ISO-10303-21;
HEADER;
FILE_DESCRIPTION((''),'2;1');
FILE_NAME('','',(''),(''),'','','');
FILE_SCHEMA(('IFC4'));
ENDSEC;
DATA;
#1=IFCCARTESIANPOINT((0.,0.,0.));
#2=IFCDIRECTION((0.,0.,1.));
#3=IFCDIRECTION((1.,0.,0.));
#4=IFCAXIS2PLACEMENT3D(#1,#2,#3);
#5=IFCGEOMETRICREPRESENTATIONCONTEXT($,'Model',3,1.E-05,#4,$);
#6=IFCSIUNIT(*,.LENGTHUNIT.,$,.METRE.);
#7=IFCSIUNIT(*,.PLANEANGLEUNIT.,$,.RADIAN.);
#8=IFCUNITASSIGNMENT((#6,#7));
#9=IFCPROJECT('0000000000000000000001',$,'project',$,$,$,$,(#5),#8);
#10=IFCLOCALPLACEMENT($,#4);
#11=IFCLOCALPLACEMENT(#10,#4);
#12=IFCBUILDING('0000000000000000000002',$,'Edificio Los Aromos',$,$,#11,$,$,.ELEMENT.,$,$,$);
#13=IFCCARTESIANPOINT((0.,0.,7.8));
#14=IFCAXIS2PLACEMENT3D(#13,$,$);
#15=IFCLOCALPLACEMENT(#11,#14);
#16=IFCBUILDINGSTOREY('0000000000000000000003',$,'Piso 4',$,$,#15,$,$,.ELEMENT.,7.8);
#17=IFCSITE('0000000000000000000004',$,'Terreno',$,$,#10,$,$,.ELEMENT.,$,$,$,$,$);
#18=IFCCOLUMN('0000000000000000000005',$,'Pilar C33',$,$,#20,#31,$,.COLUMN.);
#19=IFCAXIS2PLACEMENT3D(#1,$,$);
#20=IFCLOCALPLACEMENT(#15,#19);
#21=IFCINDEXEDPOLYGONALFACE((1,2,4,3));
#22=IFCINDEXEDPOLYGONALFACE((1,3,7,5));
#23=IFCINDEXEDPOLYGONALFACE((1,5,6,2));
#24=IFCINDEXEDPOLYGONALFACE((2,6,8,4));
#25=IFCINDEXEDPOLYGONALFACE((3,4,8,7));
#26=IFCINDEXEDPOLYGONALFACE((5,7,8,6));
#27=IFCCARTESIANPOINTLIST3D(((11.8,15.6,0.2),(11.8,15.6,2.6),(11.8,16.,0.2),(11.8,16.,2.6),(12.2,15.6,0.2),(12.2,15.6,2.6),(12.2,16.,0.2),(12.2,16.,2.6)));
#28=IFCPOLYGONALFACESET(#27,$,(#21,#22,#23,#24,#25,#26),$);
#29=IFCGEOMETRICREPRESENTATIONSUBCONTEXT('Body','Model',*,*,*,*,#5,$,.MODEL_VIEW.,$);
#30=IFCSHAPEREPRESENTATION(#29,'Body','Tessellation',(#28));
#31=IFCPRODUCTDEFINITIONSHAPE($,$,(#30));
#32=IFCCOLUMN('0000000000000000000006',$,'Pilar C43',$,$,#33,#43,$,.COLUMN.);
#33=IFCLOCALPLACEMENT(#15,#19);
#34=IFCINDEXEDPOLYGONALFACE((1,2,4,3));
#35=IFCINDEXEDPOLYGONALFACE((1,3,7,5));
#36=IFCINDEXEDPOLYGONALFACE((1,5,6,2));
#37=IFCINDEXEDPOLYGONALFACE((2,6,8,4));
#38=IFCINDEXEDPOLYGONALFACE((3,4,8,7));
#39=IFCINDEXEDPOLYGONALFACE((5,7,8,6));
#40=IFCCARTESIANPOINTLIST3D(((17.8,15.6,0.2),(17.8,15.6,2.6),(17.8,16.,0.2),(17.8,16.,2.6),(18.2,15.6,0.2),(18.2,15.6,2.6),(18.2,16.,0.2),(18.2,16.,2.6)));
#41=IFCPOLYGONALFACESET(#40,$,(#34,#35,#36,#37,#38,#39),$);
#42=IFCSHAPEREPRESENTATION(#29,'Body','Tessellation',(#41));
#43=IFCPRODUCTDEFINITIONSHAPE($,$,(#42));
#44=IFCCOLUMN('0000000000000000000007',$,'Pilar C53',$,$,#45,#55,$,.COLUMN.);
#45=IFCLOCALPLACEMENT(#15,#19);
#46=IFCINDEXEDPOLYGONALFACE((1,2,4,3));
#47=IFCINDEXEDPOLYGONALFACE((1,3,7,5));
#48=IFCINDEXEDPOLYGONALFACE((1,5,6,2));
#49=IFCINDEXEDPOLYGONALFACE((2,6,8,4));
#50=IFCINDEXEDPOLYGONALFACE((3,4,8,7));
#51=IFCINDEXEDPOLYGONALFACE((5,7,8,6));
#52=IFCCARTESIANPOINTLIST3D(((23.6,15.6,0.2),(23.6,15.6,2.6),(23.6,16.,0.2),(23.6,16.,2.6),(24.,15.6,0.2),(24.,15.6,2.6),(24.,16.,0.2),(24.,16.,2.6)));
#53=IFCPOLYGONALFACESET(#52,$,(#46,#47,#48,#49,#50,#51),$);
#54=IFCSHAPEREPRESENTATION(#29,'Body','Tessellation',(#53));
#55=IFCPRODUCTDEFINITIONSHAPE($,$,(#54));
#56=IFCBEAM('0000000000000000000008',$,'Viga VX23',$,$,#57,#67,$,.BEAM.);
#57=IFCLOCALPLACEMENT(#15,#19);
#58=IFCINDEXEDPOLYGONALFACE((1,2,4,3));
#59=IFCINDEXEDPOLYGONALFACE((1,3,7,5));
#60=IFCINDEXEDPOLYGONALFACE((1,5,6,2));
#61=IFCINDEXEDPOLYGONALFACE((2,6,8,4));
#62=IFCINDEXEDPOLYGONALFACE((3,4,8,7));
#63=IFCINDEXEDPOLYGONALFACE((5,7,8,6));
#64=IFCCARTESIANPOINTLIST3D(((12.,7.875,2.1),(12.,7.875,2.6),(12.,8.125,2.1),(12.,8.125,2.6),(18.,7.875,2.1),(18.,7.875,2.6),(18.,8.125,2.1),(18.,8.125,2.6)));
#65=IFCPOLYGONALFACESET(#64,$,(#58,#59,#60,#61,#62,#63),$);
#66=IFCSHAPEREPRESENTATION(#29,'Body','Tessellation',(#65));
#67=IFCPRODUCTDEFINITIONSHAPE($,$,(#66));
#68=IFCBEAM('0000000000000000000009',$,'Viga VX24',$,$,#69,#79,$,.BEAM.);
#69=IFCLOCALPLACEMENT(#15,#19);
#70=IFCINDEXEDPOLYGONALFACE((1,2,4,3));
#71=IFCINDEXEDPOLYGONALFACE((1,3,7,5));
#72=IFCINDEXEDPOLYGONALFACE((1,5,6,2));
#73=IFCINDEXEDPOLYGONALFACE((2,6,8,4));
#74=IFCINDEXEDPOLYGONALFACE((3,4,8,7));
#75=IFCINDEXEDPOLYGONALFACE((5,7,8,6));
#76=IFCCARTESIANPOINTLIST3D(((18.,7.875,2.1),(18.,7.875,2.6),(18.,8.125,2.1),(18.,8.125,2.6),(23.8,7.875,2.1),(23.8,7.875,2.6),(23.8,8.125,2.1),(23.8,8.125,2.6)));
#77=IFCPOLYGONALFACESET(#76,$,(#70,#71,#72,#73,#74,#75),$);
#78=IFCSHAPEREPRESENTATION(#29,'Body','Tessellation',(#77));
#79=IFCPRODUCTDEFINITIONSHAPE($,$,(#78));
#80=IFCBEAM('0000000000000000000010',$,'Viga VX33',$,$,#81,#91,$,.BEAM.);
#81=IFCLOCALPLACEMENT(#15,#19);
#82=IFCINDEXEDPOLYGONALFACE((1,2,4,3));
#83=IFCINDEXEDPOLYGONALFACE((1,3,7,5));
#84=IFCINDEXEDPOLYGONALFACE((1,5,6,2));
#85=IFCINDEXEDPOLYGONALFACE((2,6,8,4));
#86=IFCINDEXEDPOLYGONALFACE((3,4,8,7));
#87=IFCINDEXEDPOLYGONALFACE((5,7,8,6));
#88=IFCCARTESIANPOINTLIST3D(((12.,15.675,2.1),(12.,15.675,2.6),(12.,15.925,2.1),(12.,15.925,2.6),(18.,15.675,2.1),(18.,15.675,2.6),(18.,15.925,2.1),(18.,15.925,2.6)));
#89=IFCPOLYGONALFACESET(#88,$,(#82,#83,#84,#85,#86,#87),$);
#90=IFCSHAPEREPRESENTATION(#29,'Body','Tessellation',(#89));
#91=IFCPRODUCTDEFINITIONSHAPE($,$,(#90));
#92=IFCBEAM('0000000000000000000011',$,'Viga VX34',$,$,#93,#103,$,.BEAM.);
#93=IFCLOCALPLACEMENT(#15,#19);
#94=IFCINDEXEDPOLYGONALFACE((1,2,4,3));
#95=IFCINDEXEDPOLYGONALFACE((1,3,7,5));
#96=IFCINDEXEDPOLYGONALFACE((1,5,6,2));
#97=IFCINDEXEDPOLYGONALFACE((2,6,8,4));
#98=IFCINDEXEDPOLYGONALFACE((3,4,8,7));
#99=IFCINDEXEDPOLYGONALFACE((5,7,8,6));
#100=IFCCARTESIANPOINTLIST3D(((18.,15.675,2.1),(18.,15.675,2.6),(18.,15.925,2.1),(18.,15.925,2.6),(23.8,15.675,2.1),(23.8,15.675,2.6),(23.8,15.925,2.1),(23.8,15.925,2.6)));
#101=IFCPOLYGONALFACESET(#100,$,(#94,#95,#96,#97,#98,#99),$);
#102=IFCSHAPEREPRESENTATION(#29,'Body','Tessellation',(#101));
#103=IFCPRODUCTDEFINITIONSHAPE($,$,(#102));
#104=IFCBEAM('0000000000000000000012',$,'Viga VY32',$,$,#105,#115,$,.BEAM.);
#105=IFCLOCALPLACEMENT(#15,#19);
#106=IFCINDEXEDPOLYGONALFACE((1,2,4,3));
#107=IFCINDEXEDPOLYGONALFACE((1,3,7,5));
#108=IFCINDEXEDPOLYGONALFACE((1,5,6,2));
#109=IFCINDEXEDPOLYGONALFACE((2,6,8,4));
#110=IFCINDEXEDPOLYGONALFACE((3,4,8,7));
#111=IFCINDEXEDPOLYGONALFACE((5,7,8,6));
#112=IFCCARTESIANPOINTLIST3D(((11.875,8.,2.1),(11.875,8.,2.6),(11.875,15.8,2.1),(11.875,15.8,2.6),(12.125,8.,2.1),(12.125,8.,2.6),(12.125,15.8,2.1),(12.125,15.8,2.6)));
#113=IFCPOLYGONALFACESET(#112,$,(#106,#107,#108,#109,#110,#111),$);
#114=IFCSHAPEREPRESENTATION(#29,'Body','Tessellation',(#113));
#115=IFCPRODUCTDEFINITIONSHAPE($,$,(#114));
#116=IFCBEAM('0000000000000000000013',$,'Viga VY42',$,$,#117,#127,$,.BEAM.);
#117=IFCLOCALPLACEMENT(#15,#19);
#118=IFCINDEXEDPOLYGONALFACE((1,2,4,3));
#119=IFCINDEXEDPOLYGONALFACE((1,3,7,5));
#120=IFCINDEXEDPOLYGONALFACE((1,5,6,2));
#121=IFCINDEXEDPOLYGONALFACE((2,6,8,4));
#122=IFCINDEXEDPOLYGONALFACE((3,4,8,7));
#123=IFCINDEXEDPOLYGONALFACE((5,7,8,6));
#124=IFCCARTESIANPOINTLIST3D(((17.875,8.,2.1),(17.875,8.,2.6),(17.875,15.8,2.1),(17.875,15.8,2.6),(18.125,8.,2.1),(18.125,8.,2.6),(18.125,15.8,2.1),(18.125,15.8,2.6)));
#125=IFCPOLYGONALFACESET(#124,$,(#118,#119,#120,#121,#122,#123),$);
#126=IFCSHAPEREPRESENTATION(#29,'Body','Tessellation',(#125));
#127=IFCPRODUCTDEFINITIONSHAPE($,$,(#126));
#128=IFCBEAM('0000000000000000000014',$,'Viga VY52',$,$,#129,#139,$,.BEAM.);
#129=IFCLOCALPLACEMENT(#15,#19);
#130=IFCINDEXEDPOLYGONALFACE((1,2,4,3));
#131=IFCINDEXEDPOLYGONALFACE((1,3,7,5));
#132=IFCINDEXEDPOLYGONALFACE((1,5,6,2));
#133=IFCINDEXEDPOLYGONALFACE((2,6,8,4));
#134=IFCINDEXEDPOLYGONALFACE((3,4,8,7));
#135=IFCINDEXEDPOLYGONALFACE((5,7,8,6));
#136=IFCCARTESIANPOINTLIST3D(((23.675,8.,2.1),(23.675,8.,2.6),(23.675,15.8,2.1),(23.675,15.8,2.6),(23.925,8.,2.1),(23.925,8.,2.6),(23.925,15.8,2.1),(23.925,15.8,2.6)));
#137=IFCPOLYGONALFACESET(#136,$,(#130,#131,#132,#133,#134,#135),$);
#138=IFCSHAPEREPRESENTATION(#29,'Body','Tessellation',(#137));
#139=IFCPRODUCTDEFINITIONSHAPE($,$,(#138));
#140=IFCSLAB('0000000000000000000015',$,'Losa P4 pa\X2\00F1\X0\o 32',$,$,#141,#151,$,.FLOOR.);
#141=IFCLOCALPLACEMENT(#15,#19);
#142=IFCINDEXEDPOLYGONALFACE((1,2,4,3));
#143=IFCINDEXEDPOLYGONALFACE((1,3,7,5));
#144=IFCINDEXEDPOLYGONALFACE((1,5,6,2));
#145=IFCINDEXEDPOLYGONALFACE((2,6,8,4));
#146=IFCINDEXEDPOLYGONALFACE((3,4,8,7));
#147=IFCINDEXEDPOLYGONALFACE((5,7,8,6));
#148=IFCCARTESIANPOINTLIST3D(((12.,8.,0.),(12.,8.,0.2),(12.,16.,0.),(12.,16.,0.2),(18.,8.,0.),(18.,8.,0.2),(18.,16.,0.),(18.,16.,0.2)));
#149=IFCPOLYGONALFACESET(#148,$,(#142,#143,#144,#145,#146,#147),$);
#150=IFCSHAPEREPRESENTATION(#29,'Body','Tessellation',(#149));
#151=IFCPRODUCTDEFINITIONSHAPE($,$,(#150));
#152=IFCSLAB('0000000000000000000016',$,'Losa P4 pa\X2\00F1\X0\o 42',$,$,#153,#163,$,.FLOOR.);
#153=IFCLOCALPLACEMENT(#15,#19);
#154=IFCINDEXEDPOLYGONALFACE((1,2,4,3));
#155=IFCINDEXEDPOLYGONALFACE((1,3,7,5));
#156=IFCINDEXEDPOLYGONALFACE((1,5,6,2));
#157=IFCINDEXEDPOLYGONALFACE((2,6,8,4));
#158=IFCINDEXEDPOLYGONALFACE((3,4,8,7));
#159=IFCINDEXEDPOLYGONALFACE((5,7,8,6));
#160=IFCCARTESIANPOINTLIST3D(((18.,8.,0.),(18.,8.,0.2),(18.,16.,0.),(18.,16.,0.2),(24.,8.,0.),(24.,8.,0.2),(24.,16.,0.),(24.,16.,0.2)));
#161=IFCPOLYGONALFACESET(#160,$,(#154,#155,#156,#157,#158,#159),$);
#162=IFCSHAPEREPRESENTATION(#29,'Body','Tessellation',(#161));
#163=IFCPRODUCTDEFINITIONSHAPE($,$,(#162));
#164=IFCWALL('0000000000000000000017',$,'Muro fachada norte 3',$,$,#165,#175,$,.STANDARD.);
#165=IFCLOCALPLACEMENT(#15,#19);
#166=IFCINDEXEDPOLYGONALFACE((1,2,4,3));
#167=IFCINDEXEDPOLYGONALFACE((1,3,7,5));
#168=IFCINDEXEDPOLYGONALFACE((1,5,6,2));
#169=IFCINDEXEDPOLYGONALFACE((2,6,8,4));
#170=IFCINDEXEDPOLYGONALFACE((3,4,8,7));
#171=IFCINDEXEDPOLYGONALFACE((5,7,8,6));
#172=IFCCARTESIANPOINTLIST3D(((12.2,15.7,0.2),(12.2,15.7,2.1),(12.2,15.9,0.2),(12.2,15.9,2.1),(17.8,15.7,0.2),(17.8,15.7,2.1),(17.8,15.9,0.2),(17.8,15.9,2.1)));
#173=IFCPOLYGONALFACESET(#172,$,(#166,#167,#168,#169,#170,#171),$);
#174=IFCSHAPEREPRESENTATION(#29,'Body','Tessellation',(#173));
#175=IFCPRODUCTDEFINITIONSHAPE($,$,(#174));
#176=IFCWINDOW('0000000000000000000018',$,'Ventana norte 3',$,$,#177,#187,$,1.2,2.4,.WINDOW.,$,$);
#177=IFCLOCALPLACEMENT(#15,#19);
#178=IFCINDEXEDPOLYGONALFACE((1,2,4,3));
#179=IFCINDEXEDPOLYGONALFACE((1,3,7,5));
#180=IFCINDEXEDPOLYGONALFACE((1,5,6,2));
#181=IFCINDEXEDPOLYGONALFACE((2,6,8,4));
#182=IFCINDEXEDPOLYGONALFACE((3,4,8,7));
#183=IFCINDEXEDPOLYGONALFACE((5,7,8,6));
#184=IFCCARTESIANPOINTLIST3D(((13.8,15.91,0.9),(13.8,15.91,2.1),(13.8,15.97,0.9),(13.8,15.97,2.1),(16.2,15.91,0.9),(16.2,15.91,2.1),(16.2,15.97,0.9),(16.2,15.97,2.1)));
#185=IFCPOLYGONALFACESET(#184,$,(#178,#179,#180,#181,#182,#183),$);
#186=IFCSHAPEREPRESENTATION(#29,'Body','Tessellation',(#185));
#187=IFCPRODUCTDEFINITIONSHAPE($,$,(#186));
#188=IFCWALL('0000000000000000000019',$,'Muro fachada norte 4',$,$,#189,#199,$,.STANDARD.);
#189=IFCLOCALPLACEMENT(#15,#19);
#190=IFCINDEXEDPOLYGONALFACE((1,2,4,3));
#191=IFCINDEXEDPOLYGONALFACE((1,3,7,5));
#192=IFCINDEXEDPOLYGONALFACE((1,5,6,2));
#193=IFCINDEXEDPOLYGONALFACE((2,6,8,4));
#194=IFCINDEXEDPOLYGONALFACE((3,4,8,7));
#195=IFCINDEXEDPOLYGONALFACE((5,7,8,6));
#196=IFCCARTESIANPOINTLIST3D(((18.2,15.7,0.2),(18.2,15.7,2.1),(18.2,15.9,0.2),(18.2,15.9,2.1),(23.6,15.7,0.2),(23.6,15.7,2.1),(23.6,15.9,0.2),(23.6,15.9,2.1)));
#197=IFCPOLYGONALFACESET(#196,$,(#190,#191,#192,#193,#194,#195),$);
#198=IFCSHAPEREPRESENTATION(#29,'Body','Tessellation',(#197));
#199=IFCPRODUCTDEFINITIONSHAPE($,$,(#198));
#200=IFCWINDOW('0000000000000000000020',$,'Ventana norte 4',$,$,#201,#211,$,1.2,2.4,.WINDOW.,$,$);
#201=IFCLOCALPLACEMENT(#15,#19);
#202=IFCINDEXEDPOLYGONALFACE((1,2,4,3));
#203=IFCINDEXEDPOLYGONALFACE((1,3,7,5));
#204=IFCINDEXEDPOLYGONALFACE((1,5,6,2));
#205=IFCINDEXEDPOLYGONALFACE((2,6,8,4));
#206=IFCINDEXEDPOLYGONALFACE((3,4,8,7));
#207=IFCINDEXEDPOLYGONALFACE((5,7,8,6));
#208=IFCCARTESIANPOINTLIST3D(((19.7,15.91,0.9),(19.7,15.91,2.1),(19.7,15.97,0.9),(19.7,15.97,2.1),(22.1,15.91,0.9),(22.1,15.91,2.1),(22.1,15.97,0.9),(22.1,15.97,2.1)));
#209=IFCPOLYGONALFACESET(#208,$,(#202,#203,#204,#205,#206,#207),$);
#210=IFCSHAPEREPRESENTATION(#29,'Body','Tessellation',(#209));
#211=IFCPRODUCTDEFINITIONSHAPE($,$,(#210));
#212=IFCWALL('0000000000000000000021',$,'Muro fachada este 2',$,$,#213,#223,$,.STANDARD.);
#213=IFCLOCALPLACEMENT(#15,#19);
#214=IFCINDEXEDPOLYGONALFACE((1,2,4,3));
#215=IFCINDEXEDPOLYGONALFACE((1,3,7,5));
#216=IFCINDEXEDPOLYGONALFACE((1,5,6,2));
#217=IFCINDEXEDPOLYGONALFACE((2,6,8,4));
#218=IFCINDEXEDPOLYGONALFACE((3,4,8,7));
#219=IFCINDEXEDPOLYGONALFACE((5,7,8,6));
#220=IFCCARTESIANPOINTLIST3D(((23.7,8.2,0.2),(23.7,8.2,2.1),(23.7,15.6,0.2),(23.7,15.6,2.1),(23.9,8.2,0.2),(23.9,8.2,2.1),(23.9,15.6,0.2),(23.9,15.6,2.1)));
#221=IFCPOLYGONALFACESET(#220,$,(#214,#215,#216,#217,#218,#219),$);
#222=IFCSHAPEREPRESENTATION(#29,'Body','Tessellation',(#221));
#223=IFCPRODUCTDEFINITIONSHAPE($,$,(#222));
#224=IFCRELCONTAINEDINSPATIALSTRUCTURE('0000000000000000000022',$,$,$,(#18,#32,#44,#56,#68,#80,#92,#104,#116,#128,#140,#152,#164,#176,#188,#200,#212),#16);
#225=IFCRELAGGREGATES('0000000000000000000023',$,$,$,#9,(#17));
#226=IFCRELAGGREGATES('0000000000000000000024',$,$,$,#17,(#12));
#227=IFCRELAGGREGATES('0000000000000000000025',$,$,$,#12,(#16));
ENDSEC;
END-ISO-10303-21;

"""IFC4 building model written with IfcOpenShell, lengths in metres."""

from ifc_helpers import new_model, si_unit, frame, frame_2d, origin_with_axes, place, context, subcontext, project, spatial, rectangle, extrude, element, save


model = new_model("IFC4")

# Units and contexts
model_context = context("Model", 3, precision=1e-05, world=origin_with_axes())
body_context = subcontext(model_context, "Body", "Model", "MODEL_VIEW")
ifc_project = project(units=[si_unit("LENGTHUNIT", "METRE"), si_unit("PLANEANGLEUNIT", "RADIAN")], contexts=[model_context])

# Site, building, storey
site_placement = place(None, origin_with_axes())
site = spatial("IfcSite", under=ifc_project, at=site_placement, Name="Terreno", CompositionType="ELEMENT")
building_placement = place(site_placement, origin_with_axes())
building = spatial("IfcBuilding", under=site, at=building_placement, Name="Edificio Los Aromos", CompositionType="ELEMENT")
storey_placement = place(building_placement, frame((0.0, 0.0, 7.8)))
storey = spatial("IfcBuildingStorey", under=building, at=storey_placement, Name="Piso 4", CompositionType="ELEMENT", Elevation=7.8)

# Columns
for number, where, name in (
    (1, (11.8, 15.6, 0.2), "Pilar C33"),
    (2, (17.8, 15.6, 0.2), "Pilar C43"),
    (3, (23.6, 15.6, 0.2), "Pilar C53"),
):
    element("IfcColumn", number, at=place(storey_placement, frame(where)), inside=storey, Name=name, PredefinedType="COLUMN", context=body_context, shape_type="SweptSolid", body=[
        extrude(rectangle(XDim=0.4, YDim=0.4, at=frame_2d((0.2, 0.2))), origin_with_axes(), (0.0, 0.0, 1.0), 2.4),
    ])

# Beams
beam_1_placement = place(storey_placement, frame((12.0, 7.875, 2.1)))
element("IfcBeam", 4, at=beam_1_placement, inside=storey, Name="Viga VX23", PredefinedType="BEAM", context=body_context, shape_type="SweptSolid", body=[
    extrude(rectangle(XDim=6.0, YDim=0.25, at=frame_2d((3.0, 0.125))), origin_with_axes(), (0.0, 0.0, 1.0), 0.5),
])
beam_2_placement = place(storey_placement, frame((18.0, 7.875, 2.1)))
element("IfcBeam", 5, at=beam_2_placement, inside=storey, Name="Viga VX24", PredefinedType="BEAM", context=body_context, shape_type="SweptSolid", body=[
    extrude(rectangle(XDim=5.8, YDim=0.25, at=frame_2d((2.9, 0.125))), origin_with_axes(), (0.0, 0.0, 1.0), 0.5),
])
beam_3_placement = place(storey_placement, frame((12.0, 15.675, 2.1)))
element("IfcBeam", 6, at=beam_3_placement, inside=storey, Name="Viga VX33", PredefinedType="BEAM", context=body_context, shape_type="SweptSolid", body=[
    extrude(rectangle(XDim=6.0, YDim=0.25, at=frame_2d((3.0, 0.125))), origin_with_axes(), (0.0, 0.0, 1.0), 0.5),
])
beam_4_placement = place(storey_placement, frame((18.0, 15.675, 2.1)))
element("IfcBeam", 7, at=beam_4_placement, inside=storey, Name="Viga VX34", PredefinedType="BEAM", context=body_context, shape_type="SweptSolid", body=[
    extrude(rectangle(XDim=5.8, YDim=0.25, at=frame_2d((2.9, 0.125))), origin_with_axes(), (0.0, 0.0, 1.0), 0.5),
])
for number, where, name in (
    (8, (11.875, 8.0, 2.1), "Viga VY32"),
    (9, (17.875, 8.0, 2.1), "Viga VY42"),
    (10, (23.675, 8.0, 2.1), "Viga VY52"),
):
    element("IfcBeam", number, at=place(storey_placement, frame(where)), inside=storey, Name=name, PredefinedType="BEAM", context=body_context, shape_type="SweptSolid", body=[
        extrude(rectangle(XDim=0.25, YDim=7.8, at=frame_2d((0.125, 3.9))), origin_with_axes(), (0.0, 0.0, 1.0), 0.5),
    ])

# Slabs
for number, where, name in (
    (11, (12.0, 8.0, 0.0), "Losa P4 paño 32"),
    (12, (18.0, 8.0, 0.0), "Losa P4 paño 42"),
):
    element("IfcSlab", number, at=place(storey_placement, frame(where)), inside=storey, Name=name, PredefinedType="FLOOR", context=body_context, shape_type="SweptSolid", body=[
        extrude(rectangle(XDim=6.0, YDim=8.0, at=frame_2d((3.0, 4.0))), origin_with_axes(), (0.0, 0.0, 1.0), 0.2),
    ])

# Wall
wall_1_placement = place(storey_placement, frame((12.2, 15.7, 0.2)))
element("IfcWall", 13, at=wall_1_placement, inside=storey, Name="Muro fachada norte 3", PredefinedType="STANDARD", context=body_context, shape_type="SweptSolid", body=[
    extrude(rectangle(XDim=5.6, YDim=0.2, at=frame_2d((2.8, 0.1))), origin_with_axes(), (0.0, 0.0, 1.0), 1.9),
])

# Window
window_1_placement = place(storey_placement, frame((13.8, 15.91, 0.9)))
element("IfcWindow", 14, at=window_1_placement, inside=storey, Name="Ventana norte 3", OverallHeight=1.2, OverallWidth=2.4, PredefinedType="WINDOW", context=body_context, shape_type="SweptSolid", body=[
    extrude(rectangle(XDim=2.4, YDim=0.06, at=frame_2d((1.2, 0.03))), origin_with_axes(), (0.0, 0.0, 1.0), 1.2),
])

# Wall
wall_2_placement = place(storey_placement, frame((18.2, 15.7, 0.2)))
element("IfcWall", 15, at=wall_2_placement, inside=storey, Name="Muro fachada norte 4", PredefinedType="STANDARD", context=body_context, shape_type="SweptSolid", body=[
    extrude(rectangle(XDim=5.4, YDim=0.2, at=frame_2d((2.7, 0.1))), origin_with_axes(), (0.0, 0.0, 1.0), 1.9),
])

# Window
window_2_placement = place(storey_placement, frame((19.7, 15.91, 0.9)))
element("IfcWindow", 16, at=window_2_placement, inside=storey, Name="Ventana norte 4", OverallHeight=1.2, OverallWidth=2.4, PredefinedType="WINDOW", context=body_context, shape_type="SweptSolid", body=[
    extrude(rectangle(XDim=2.4, YDim=0.06, at=frame_2d((1.2, 0.03))), origin_with_axes(), (0.0, 0.0, 1.0), 1.2),
])

# Wall
wall_3_placement = place(storey_placement, frame((23.7, 8.2, 0.2)))
element("IfcWall", 17, at=wall_3_placement, inside=storey, Name="Muro fachada este 2", PredefinedType="STANDARD", context=body_context, shape_type="SweptSolid", body=[
    extrude(rectangle(XDim=0.2, YDim=7.4, at=frame_2d((0.1, 3.7))), origin_with_axes(), (0.0, 0.0, 1.0), 1.9),
])

save(model, "model.ifc")
